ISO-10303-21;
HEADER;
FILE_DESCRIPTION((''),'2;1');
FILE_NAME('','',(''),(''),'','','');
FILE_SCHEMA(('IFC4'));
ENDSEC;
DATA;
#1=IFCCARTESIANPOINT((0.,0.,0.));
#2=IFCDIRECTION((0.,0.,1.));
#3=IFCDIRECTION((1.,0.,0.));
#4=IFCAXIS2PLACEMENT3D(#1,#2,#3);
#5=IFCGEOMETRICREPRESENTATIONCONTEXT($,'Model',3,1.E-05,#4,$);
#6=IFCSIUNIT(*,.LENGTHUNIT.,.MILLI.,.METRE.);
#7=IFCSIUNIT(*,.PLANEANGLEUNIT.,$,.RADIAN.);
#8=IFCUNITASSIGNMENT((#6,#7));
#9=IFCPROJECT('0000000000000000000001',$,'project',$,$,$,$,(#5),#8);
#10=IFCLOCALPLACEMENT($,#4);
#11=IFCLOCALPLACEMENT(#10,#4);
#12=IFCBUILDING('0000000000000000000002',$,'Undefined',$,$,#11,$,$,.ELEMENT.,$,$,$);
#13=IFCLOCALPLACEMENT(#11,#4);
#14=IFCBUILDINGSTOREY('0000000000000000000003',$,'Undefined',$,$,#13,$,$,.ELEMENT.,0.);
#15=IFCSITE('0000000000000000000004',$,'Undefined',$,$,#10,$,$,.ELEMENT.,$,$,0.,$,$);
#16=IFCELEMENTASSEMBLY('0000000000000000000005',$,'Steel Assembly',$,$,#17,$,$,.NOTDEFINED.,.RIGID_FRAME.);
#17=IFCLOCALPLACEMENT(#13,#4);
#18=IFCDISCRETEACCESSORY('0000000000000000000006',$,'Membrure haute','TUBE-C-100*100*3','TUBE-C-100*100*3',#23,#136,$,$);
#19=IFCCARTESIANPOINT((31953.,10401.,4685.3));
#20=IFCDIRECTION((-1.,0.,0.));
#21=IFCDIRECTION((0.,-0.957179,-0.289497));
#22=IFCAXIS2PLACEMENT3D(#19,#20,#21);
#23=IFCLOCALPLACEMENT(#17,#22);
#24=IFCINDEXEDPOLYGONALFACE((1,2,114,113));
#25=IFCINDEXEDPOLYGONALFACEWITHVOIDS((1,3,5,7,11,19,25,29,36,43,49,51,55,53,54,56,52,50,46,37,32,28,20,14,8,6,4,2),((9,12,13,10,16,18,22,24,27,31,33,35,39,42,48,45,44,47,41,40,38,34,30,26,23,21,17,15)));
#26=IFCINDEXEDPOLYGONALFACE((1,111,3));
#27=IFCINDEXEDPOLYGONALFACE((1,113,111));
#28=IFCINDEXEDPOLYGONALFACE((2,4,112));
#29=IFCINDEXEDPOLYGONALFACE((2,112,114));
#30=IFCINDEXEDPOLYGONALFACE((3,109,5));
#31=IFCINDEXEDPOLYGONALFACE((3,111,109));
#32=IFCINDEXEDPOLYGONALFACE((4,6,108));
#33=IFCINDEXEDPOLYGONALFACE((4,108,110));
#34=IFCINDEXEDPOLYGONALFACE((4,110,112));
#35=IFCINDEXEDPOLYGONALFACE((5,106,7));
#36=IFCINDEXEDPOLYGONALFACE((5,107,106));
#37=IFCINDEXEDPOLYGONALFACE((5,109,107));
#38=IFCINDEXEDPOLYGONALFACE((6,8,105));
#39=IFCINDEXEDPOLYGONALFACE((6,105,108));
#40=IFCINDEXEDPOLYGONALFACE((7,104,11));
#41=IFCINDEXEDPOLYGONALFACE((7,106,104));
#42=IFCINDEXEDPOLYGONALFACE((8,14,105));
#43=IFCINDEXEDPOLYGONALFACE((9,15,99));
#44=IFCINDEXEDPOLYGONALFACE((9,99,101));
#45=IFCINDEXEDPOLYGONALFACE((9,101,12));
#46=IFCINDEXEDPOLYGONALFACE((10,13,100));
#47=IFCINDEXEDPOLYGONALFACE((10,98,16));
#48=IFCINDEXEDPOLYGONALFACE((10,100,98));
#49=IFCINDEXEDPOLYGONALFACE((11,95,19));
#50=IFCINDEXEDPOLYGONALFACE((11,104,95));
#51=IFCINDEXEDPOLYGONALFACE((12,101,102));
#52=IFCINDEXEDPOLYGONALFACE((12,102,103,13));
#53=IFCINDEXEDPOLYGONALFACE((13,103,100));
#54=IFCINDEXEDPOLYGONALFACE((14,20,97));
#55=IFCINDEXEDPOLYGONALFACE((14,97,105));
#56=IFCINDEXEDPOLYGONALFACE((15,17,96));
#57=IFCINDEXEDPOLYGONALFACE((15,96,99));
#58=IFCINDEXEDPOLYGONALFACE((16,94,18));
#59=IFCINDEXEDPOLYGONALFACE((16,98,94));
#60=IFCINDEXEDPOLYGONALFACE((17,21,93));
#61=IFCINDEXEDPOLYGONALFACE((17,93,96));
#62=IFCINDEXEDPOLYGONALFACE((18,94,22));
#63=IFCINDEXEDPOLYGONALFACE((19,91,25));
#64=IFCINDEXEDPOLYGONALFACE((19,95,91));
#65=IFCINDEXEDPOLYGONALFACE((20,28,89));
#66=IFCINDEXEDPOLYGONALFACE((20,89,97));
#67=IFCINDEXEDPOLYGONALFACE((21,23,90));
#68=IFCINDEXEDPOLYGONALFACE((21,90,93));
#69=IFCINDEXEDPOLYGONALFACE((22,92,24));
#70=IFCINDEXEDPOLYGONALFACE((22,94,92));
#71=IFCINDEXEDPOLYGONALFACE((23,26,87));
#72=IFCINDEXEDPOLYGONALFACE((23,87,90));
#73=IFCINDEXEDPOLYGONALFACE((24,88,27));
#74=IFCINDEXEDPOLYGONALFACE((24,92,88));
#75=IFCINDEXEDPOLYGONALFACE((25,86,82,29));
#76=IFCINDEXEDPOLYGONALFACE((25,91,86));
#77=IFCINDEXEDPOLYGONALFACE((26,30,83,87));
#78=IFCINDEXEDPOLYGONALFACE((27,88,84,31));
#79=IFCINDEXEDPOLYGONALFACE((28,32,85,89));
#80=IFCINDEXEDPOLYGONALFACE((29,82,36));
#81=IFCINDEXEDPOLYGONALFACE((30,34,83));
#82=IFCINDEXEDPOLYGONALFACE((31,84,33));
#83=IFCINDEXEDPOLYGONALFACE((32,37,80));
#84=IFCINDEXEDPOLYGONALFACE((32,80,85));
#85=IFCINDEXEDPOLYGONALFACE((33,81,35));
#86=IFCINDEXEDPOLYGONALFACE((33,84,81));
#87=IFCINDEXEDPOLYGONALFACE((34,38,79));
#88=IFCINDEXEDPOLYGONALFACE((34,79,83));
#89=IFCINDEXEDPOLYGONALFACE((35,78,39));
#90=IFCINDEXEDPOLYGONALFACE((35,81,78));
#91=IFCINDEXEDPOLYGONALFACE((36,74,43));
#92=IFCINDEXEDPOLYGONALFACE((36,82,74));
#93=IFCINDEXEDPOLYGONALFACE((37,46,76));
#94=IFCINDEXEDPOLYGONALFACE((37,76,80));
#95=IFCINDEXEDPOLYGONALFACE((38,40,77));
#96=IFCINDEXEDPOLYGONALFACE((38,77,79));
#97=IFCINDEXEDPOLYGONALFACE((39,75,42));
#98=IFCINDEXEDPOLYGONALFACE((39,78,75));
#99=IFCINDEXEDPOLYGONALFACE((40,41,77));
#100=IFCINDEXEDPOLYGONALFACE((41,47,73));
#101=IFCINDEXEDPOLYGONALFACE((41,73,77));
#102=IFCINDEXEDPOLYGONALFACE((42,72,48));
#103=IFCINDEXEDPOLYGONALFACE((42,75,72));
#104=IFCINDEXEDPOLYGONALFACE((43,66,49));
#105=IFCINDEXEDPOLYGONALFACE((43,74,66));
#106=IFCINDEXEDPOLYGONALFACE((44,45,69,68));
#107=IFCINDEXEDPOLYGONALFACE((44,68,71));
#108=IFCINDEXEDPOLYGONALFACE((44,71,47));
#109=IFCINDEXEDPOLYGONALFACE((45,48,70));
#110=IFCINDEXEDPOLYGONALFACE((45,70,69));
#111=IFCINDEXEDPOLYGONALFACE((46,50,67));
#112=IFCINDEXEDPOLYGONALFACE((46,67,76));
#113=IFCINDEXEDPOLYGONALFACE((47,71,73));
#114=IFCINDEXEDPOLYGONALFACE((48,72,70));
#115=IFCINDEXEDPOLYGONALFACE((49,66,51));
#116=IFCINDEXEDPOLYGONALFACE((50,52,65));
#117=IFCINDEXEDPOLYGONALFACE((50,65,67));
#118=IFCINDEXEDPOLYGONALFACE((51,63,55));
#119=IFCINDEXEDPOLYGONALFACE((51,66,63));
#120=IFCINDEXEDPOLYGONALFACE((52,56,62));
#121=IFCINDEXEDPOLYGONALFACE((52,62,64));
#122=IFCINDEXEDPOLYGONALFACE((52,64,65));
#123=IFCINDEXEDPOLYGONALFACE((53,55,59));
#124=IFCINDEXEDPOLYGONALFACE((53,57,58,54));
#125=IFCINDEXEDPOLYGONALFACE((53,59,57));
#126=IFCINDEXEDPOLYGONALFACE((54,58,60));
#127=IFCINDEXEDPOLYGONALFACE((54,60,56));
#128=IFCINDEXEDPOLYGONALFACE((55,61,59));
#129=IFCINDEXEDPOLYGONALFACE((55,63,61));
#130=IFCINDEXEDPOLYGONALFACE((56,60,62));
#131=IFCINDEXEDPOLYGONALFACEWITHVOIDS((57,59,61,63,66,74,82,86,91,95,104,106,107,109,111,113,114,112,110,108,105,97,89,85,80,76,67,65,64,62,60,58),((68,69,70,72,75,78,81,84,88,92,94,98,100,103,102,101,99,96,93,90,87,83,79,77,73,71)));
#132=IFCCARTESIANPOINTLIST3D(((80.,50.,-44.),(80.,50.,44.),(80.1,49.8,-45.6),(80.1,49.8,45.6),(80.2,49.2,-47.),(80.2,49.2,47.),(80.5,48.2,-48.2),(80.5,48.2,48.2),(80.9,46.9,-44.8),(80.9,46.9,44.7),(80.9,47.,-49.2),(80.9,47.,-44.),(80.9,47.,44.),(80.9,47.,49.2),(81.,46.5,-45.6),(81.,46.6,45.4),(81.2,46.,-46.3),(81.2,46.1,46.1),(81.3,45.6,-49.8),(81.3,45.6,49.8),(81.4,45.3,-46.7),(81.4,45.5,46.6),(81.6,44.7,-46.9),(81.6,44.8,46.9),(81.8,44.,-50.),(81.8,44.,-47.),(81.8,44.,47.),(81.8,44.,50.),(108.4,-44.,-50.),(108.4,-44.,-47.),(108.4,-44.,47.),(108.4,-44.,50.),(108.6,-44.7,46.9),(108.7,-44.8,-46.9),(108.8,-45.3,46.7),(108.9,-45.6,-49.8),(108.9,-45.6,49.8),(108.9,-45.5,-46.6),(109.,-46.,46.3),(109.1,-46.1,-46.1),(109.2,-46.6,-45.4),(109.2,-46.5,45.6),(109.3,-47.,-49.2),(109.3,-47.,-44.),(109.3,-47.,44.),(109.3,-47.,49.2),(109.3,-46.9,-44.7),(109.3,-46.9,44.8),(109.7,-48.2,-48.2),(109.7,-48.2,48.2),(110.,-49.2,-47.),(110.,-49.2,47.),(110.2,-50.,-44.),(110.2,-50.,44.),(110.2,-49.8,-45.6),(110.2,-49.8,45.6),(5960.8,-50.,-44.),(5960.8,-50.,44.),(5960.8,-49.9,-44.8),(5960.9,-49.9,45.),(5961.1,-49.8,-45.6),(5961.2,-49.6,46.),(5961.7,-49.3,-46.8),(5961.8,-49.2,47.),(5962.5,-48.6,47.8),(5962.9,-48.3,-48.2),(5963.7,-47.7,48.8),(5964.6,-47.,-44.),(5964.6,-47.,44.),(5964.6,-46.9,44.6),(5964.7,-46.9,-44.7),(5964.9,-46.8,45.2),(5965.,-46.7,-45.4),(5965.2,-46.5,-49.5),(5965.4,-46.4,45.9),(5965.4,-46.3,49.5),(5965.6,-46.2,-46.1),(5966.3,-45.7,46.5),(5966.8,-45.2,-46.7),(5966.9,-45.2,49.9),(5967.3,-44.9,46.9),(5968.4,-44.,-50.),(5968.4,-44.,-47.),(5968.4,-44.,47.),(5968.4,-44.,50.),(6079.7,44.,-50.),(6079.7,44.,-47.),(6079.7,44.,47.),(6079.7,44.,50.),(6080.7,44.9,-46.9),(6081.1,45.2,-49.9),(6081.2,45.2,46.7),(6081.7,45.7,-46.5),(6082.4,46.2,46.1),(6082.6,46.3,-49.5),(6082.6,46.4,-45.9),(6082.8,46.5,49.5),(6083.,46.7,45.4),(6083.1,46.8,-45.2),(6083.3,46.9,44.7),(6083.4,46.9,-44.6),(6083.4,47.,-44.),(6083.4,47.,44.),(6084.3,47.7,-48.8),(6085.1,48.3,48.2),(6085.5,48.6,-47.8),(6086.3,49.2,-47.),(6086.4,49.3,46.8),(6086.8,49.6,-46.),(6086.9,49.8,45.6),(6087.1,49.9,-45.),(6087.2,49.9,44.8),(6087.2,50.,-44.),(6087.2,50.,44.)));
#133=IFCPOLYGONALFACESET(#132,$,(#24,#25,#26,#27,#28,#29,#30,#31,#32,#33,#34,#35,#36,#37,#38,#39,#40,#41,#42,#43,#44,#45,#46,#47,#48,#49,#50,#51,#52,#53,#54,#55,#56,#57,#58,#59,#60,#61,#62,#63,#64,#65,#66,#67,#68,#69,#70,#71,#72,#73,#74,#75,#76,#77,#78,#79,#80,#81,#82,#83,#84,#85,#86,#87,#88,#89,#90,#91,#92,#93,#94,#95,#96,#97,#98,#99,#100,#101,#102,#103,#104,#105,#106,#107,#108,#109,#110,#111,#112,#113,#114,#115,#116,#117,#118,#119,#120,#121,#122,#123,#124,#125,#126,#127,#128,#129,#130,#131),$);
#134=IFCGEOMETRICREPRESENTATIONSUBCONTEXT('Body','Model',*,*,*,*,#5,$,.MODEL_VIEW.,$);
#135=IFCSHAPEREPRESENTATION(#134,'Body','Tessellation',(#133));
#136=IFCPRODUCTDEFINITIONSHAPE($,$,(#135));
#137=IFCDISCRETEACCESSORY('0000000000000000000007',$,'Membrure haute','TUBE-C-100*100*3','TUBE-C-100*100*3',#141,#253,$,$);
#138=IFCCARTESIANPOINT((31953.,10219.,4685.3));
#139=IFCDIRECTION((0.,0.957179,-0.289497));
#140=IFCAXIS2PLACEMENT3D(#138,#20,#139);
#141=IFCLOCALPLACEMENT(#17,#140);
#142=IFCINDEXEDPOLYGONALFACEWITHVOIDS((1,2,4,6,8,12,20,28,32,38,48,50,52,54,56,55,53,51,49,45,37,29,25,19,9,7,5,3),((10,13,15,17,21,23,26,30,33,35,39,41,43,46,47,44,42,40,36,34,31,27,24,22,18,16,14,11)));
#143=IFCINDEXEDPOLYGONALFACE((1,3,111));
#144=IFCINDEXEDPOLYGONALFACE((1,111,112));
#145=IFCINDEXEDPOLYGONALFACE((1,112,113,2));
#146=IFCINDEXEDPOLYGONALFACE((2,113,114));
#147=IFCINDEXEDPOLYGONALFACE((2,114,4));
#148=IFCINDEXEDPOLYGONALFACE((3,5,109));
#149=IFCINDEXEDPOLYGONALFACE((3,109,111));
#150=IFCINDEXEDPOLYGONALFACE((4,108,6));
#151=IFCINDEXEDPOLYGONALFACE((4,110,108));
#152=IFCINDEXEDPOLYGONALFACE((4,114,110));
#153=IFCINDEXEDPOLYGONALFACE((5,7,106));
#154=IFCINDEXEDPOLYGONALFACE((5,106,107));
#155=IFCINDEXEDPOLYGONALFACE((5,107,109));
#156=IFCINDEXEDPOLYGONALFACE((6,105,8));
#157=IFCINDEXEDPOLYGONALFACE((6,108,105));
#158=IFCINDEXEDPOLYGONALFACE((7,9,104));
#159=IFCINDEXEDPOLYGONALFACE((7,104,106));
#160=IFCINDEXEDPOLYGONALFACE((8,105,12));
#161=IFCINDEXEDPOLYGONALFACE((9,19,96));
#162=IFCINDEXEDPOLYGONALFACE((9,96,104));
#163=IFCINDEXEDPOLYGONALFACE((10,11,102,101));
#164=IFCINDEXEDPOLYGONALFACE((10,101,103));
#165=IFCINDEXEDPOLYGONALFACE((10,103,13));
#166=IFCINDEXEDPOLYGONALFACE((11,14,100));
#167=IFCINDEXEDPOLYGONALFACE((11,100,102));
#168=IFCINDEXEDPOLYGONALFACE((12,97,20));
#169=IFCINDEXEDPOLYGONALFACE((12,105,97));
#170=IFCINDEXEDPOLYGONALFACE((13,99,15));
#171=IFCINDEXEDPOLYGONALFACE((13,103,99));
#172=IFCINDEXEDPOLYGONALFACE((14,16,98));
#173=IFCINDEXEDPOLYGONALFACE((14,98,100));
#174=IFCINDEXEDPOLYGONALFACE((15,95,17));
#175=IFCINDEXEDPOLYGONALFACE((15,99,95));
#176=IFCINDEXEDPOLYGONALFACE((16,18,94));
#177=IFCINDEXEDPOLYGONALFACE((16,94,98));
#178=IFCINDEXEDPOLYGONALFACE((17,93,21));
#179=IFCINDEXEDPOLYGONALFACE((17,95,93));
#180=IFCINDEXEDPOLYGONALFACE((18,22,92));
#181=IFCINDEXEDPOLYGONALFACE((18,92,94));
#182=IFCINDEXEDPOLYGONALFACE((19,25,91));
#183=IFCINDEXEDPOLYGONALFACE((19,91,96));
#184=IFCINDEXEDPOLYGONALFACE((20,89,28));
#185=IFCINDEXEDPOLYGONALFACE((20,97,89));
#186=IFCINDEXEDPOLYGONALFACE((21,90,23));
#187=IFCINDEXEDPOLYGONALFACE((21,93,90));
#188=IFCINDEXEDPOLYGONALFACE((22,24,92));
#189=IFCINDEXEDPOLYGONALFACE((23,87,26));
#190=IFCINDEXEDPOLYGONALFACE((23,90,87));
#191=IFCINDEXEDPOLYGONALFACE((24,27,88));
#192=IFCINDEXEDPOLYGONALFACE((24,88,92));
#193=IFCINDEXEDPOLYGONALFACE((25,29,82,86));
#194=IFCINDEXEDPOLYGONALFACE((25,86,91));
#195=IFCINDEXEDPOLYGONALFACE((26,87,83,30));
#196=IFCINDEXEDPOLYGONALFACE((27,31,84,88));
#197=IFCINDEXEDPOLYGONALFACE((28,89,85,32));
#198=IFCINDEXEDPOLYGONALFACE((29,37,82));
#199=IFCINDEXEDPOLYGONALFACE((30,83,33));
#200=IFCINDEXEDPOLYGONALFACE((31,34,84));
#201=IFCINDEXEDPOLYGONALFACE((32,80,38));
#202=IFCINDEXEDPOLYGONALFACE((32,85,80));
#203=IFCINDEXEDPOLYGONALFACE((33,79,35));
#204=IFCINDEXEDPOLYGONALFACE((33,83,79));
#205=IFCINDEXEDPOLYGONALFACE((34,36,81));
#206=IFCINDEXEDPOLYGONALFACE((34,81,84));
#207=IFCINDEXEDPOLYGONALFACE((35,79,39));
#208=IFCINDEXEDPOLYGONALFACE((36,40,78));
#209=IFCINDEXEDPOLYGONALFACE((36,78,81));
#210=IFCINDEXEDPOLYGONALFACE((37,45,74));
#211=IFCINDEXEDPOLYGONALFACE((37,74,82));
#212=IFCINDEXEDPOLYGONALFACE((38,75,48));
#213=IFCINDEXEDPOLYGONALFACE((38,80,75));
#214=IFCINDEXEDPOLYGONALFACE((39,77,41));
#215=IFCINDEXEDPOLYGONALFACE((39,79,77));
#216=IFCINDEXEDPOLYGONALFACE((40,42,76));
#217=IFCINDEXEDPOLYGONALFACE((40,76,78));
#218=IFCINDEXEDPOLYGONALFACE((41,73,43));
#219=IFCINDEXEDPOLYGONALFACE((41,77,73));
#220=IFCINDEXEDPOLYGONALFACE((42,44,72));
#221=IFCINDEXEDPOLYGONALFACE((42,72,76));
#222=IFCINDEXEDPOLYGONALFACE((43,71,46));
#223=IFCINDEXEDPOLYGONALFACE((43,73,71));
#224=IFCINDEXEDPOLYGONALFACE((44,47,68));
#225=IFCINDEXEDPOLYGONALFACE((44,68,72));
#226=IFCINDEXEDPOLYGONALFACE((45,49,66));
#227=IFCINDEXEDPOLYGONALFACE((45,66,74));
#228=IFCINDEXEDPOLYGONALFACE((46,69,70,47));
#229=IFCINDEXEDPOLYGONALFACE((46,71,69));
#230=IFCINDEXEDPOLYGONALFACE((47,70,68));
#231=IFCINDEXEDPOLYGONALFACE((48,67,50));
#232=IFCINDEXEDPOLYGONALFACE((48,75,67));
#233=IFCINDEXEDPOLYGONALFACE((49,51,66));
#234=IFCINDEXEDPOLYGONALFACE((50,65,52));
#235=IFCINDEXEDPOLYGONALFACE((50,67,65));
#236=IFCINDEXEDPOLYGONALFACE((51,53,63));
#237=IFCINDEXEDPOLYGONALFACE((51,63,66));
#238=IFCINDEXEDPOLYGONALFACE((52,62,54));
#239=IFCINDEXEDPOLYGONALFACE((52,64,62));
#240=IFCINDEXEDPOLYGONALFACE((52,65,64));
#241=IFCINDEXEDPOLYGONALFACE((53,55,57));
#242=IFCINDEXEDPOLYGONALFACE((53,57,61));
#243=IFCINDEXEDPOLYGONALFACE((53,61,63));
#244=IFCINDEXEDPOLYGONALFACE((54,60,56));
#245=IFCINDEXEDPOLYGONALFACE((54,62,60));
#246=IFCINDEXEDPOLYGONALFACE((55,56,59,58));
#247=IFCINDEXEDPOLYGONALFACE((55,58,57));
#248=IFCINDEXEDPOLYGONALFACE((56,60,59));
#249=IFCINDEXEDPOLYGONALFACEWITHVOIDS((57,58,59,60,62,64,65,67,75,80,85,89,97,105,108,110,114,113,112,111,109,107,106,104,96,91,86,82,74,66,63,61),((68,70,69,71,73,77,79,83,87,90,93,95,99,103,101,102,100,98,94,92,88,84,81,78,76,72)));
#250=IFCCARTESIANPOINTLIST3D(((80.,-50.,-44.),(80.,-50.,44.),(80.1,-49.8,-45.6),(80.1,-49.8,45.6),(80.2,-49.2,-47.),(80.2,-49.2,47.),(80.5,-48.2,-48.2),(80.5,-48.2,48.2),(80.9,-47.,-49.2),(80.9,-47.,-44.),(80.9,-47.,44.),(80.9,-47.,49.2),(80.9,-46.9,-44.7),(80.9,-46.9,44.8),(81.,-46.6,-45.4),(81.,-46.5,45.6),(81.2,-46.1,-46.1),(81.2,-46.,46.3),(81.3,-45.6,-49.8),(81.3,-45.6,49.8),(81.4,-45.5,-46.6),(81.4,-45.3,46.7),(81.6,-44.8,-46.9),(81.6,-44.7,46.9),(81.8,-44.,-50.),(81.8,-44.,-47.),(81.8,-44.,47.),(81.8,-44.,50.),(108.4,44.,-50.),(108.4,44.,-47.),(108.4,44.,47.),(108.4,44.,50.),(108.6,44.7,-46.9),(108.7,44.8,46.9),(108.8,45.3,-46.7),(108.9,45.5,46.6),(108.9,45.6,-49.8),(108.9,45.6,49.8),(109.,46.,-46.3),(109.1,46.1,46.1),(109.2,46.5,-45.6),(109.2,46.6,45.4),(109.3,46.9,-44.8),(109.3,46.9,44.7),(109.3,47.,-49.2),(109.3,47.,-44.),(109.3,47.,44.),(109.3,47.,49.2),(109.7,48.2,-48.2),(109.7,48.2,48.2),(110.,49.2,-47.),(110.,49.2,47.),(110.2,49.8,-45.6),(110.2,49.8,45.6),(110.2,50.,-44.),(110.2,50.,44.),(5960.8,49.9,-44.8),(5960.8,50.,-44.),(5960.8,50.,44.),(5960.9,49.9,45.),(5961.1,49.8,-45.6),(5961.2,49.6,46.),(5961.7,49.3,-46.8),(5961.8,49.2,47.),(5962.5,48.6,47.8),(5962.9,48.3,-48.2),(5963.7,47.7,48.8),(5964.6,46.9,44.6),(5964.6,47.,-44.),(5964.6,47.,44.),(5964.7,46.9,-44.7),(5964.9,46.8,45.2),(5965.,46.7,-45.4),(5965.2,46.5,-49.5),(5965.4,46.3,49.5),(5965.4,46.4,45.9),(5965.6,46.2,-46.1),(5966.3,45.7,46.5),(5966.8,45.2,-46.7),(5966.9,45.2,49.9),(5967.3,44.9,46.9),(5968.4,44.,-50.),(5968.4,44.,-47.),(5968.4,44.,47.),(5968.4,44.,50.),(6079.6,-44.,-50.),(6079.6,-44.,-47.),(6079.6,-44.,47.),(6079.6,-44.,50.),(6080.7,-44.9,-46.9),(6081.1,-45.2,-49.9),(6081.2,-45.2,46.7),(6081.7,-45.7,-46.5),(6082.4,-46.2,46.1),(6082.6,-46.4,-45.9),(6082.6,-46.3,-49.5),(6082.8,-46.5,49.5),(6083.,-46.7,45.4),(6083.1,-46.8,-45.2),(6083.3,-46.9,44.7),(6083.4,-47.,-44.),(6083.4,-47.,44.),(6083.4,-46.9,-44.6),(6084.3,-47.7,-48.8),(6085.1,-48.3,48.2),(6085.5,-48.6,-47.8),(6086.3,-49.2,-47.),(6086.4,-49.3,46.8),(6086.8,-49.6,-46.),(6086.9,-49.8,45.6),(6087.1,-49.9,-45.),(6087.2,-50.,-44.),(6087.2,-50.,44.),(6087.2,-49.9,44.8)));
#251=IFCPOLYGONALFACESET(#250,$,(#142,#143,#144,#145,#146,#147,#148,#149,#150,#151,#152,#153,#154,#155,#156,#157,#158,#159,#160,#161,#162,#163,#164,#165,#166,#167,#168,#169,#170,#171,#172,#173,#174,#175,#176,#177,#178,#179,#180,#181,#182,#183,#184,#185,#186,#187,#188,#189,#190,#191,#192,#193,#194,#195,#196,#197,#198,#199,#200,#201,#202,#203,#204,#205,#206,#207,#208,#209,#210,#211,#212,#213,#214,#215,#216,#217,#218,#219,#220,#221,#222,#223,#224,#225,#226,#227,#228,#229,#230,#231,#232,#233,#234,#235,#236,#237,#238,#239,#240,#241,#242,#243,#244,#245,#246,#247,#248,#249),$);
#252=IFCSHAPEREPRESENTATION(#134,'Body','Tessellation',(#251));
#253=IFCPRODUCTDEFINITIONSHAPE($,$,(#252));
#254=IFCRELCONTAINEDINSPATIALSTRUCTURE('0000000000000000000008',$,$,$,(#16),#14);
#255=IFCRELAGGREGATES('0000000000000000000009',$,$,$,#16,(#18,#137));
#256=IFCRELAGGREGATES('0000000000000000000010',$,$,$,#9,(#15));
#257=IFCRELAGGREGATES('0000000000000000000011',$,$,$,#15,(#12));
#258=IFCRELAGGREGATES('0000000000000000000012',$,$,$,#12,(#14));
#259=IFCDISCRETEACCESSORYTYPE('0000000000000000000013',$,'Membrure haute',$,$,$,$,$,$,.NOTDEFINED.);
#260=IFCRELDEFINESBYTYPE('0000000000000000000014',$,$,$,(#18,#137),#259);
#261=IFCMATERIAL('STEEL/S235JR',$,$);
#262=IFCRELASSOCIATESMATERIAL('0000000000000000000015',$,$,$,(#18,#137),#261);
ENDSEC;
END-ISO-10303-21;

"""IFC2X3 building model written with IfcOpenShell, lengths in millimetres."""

from ifc_helpers import new_model, si_unit, frame, origin_with_axes, origin_2d_with_axis, place, context, subcontext, project, spatial, hollow_rectangle, extrude, clip, halfspace, material, type_object, element, aggregate, save


model = new_model("IFC2X3")

# Units and contexts
model_context = context("Model", 3, precision=1e-05, world=origin_with_axes())
body_context = subcontext(model_context, "Body", "Model", "MODEL_VIEW")
ifc_project = project(units=[si_unit("LENGTHUNIT", "METRE", prefix="MILLI"), si_unit("PLANEANGLEUNIT", "RADIAN")], contexts=[model_context])

# Site, building, storey
site_placement = place(None, origin_with_axes())
site = spatial("IfcSite", under=ifc_project, at=site_placement, Name="Undefined", CompositionType="ELEMENT", RefElevation=0.0)
building_placement = place(site_placement, origin_with_axes())
building = spatial("IfcBuilding", under=site, at=building_placement, Name="Undefined", CompositionType="ELEMENT")
storey_placement = place(building_placement, origin_with_axes())
storey = spatial("IfcBuildingStorey", under=building, at=storey_placement, Name="Undefined", CompositionType="ELEMENT", Elevation=0.0)

# Element assembly, discrete accessories
ifc_material_1 = material(Name="STEEL/S235JR")
assembly_1_placement = place(storey_placement, origin_with_axes())
assembly_1 = element("IfcElementAssembly", 1, at=assembly_1_placement, inside=storey, Name="Steel Assembly", AssemblyPlace="NOTDEFINED", PredefinedType="RIGID_FRAME")
discrete_accessory_type_1 = type_object("IfcDiscreteAccessoryType", Name="Membrure haute")
discrete_accessory_1_placement = place(assembly_1_placement, frame((31953.0, 10401.0, 4685.3), z_axis=(-1.0, 0.0, 0.0), x_axis=(0.0, -0.957179, -0.289497)))
discrete_accessory_1 = element("IfcDiscreteAccessory", 2, at=discrete_accessory_1_placement, type_object=discrete_accessory_type_1, material=ifc_material_1, Name="Membrure haute", Description="TUBE-C-100*100*3", ObjectType="TUBE-C-100*100*3", context=body_context, shape_type="Clipping", body=[
    clip(clip(extrude(hollow_rectangle(XDim=100.0, YDim=100.0, WallThickness=3.0, InnerFilletRadius=3.0, OuterFilletRadius=6.0, at=origin_2d_with_axis()), frame((6120.4, 0.0, 0.0), z_axis=(-1.0, 0.0, 0.0), x_axis=(0.0, -1.0, 0.0)), (0.0, 0.0, 1.0), 6121.7), halfspace(frame((5960.8, -50.0, -50.0), z_axis=(-0.620241, 0.784411, 0.0), x_axis=(0.0, 0.0, -1.0)), True)), halfspace(frame((64.4, 101.5, 0.0), z_axis=(-0.957179, -0.289497, 0.0), x_axis=(0.289497, -0.957179, 0.0)), False)),
])
discrete_accessory_2_placement = place(assembly_1_placement, frame((31953.0, 10219.0, 4685.3), z_axis=(-1.0, 0.0, 0.0), x_axis=(0.0, 0.957179, -0.289497)))
discrete_accessory_2 = element("IfcDiscreteAccessory", 3, at=discrete_accessory_2_placement, type_object=discrete_accessory_type_1, material=ifc_material_1, Name="Membrure haute", Description="TUBE-C-100*100*3", ObjectType="TUBE-C-100*100*3", context=body_context, shape_type="Clipping", body=[
    clip(clip(extrude(hollow_rectangle(XDim=100.0, YDim=100.0, WallThickness=3.0, InnerFilletRadius=3.0, OuterFilletRadius=6.0, at=origin_2d_with_axis()), frame((6120.4, 0.0, 0.0), z_axis=(-1.0, 0.0, 0.0), x_axis=(0.0, -1.0, 0.0)), (0.0, 0.0, 1.0), 6121.7), halfspace(frame((5960.8, 50.0, -50.0), z_axis=(0.62025, 0.784404, 0.0), x_axis=(0.0, 0.0, -1.0)), False)), halfspace(frame((64.4, -101.5, 0.0), z_axis=(-0.957179, 0.289497, 0.0), x_axis=(0.0, 0.0, -1.0)), False)),
])
aggregate(assembly_1, [discrete_accessory_1, discrete_accessory_2])

save(model, "model.ifc")
